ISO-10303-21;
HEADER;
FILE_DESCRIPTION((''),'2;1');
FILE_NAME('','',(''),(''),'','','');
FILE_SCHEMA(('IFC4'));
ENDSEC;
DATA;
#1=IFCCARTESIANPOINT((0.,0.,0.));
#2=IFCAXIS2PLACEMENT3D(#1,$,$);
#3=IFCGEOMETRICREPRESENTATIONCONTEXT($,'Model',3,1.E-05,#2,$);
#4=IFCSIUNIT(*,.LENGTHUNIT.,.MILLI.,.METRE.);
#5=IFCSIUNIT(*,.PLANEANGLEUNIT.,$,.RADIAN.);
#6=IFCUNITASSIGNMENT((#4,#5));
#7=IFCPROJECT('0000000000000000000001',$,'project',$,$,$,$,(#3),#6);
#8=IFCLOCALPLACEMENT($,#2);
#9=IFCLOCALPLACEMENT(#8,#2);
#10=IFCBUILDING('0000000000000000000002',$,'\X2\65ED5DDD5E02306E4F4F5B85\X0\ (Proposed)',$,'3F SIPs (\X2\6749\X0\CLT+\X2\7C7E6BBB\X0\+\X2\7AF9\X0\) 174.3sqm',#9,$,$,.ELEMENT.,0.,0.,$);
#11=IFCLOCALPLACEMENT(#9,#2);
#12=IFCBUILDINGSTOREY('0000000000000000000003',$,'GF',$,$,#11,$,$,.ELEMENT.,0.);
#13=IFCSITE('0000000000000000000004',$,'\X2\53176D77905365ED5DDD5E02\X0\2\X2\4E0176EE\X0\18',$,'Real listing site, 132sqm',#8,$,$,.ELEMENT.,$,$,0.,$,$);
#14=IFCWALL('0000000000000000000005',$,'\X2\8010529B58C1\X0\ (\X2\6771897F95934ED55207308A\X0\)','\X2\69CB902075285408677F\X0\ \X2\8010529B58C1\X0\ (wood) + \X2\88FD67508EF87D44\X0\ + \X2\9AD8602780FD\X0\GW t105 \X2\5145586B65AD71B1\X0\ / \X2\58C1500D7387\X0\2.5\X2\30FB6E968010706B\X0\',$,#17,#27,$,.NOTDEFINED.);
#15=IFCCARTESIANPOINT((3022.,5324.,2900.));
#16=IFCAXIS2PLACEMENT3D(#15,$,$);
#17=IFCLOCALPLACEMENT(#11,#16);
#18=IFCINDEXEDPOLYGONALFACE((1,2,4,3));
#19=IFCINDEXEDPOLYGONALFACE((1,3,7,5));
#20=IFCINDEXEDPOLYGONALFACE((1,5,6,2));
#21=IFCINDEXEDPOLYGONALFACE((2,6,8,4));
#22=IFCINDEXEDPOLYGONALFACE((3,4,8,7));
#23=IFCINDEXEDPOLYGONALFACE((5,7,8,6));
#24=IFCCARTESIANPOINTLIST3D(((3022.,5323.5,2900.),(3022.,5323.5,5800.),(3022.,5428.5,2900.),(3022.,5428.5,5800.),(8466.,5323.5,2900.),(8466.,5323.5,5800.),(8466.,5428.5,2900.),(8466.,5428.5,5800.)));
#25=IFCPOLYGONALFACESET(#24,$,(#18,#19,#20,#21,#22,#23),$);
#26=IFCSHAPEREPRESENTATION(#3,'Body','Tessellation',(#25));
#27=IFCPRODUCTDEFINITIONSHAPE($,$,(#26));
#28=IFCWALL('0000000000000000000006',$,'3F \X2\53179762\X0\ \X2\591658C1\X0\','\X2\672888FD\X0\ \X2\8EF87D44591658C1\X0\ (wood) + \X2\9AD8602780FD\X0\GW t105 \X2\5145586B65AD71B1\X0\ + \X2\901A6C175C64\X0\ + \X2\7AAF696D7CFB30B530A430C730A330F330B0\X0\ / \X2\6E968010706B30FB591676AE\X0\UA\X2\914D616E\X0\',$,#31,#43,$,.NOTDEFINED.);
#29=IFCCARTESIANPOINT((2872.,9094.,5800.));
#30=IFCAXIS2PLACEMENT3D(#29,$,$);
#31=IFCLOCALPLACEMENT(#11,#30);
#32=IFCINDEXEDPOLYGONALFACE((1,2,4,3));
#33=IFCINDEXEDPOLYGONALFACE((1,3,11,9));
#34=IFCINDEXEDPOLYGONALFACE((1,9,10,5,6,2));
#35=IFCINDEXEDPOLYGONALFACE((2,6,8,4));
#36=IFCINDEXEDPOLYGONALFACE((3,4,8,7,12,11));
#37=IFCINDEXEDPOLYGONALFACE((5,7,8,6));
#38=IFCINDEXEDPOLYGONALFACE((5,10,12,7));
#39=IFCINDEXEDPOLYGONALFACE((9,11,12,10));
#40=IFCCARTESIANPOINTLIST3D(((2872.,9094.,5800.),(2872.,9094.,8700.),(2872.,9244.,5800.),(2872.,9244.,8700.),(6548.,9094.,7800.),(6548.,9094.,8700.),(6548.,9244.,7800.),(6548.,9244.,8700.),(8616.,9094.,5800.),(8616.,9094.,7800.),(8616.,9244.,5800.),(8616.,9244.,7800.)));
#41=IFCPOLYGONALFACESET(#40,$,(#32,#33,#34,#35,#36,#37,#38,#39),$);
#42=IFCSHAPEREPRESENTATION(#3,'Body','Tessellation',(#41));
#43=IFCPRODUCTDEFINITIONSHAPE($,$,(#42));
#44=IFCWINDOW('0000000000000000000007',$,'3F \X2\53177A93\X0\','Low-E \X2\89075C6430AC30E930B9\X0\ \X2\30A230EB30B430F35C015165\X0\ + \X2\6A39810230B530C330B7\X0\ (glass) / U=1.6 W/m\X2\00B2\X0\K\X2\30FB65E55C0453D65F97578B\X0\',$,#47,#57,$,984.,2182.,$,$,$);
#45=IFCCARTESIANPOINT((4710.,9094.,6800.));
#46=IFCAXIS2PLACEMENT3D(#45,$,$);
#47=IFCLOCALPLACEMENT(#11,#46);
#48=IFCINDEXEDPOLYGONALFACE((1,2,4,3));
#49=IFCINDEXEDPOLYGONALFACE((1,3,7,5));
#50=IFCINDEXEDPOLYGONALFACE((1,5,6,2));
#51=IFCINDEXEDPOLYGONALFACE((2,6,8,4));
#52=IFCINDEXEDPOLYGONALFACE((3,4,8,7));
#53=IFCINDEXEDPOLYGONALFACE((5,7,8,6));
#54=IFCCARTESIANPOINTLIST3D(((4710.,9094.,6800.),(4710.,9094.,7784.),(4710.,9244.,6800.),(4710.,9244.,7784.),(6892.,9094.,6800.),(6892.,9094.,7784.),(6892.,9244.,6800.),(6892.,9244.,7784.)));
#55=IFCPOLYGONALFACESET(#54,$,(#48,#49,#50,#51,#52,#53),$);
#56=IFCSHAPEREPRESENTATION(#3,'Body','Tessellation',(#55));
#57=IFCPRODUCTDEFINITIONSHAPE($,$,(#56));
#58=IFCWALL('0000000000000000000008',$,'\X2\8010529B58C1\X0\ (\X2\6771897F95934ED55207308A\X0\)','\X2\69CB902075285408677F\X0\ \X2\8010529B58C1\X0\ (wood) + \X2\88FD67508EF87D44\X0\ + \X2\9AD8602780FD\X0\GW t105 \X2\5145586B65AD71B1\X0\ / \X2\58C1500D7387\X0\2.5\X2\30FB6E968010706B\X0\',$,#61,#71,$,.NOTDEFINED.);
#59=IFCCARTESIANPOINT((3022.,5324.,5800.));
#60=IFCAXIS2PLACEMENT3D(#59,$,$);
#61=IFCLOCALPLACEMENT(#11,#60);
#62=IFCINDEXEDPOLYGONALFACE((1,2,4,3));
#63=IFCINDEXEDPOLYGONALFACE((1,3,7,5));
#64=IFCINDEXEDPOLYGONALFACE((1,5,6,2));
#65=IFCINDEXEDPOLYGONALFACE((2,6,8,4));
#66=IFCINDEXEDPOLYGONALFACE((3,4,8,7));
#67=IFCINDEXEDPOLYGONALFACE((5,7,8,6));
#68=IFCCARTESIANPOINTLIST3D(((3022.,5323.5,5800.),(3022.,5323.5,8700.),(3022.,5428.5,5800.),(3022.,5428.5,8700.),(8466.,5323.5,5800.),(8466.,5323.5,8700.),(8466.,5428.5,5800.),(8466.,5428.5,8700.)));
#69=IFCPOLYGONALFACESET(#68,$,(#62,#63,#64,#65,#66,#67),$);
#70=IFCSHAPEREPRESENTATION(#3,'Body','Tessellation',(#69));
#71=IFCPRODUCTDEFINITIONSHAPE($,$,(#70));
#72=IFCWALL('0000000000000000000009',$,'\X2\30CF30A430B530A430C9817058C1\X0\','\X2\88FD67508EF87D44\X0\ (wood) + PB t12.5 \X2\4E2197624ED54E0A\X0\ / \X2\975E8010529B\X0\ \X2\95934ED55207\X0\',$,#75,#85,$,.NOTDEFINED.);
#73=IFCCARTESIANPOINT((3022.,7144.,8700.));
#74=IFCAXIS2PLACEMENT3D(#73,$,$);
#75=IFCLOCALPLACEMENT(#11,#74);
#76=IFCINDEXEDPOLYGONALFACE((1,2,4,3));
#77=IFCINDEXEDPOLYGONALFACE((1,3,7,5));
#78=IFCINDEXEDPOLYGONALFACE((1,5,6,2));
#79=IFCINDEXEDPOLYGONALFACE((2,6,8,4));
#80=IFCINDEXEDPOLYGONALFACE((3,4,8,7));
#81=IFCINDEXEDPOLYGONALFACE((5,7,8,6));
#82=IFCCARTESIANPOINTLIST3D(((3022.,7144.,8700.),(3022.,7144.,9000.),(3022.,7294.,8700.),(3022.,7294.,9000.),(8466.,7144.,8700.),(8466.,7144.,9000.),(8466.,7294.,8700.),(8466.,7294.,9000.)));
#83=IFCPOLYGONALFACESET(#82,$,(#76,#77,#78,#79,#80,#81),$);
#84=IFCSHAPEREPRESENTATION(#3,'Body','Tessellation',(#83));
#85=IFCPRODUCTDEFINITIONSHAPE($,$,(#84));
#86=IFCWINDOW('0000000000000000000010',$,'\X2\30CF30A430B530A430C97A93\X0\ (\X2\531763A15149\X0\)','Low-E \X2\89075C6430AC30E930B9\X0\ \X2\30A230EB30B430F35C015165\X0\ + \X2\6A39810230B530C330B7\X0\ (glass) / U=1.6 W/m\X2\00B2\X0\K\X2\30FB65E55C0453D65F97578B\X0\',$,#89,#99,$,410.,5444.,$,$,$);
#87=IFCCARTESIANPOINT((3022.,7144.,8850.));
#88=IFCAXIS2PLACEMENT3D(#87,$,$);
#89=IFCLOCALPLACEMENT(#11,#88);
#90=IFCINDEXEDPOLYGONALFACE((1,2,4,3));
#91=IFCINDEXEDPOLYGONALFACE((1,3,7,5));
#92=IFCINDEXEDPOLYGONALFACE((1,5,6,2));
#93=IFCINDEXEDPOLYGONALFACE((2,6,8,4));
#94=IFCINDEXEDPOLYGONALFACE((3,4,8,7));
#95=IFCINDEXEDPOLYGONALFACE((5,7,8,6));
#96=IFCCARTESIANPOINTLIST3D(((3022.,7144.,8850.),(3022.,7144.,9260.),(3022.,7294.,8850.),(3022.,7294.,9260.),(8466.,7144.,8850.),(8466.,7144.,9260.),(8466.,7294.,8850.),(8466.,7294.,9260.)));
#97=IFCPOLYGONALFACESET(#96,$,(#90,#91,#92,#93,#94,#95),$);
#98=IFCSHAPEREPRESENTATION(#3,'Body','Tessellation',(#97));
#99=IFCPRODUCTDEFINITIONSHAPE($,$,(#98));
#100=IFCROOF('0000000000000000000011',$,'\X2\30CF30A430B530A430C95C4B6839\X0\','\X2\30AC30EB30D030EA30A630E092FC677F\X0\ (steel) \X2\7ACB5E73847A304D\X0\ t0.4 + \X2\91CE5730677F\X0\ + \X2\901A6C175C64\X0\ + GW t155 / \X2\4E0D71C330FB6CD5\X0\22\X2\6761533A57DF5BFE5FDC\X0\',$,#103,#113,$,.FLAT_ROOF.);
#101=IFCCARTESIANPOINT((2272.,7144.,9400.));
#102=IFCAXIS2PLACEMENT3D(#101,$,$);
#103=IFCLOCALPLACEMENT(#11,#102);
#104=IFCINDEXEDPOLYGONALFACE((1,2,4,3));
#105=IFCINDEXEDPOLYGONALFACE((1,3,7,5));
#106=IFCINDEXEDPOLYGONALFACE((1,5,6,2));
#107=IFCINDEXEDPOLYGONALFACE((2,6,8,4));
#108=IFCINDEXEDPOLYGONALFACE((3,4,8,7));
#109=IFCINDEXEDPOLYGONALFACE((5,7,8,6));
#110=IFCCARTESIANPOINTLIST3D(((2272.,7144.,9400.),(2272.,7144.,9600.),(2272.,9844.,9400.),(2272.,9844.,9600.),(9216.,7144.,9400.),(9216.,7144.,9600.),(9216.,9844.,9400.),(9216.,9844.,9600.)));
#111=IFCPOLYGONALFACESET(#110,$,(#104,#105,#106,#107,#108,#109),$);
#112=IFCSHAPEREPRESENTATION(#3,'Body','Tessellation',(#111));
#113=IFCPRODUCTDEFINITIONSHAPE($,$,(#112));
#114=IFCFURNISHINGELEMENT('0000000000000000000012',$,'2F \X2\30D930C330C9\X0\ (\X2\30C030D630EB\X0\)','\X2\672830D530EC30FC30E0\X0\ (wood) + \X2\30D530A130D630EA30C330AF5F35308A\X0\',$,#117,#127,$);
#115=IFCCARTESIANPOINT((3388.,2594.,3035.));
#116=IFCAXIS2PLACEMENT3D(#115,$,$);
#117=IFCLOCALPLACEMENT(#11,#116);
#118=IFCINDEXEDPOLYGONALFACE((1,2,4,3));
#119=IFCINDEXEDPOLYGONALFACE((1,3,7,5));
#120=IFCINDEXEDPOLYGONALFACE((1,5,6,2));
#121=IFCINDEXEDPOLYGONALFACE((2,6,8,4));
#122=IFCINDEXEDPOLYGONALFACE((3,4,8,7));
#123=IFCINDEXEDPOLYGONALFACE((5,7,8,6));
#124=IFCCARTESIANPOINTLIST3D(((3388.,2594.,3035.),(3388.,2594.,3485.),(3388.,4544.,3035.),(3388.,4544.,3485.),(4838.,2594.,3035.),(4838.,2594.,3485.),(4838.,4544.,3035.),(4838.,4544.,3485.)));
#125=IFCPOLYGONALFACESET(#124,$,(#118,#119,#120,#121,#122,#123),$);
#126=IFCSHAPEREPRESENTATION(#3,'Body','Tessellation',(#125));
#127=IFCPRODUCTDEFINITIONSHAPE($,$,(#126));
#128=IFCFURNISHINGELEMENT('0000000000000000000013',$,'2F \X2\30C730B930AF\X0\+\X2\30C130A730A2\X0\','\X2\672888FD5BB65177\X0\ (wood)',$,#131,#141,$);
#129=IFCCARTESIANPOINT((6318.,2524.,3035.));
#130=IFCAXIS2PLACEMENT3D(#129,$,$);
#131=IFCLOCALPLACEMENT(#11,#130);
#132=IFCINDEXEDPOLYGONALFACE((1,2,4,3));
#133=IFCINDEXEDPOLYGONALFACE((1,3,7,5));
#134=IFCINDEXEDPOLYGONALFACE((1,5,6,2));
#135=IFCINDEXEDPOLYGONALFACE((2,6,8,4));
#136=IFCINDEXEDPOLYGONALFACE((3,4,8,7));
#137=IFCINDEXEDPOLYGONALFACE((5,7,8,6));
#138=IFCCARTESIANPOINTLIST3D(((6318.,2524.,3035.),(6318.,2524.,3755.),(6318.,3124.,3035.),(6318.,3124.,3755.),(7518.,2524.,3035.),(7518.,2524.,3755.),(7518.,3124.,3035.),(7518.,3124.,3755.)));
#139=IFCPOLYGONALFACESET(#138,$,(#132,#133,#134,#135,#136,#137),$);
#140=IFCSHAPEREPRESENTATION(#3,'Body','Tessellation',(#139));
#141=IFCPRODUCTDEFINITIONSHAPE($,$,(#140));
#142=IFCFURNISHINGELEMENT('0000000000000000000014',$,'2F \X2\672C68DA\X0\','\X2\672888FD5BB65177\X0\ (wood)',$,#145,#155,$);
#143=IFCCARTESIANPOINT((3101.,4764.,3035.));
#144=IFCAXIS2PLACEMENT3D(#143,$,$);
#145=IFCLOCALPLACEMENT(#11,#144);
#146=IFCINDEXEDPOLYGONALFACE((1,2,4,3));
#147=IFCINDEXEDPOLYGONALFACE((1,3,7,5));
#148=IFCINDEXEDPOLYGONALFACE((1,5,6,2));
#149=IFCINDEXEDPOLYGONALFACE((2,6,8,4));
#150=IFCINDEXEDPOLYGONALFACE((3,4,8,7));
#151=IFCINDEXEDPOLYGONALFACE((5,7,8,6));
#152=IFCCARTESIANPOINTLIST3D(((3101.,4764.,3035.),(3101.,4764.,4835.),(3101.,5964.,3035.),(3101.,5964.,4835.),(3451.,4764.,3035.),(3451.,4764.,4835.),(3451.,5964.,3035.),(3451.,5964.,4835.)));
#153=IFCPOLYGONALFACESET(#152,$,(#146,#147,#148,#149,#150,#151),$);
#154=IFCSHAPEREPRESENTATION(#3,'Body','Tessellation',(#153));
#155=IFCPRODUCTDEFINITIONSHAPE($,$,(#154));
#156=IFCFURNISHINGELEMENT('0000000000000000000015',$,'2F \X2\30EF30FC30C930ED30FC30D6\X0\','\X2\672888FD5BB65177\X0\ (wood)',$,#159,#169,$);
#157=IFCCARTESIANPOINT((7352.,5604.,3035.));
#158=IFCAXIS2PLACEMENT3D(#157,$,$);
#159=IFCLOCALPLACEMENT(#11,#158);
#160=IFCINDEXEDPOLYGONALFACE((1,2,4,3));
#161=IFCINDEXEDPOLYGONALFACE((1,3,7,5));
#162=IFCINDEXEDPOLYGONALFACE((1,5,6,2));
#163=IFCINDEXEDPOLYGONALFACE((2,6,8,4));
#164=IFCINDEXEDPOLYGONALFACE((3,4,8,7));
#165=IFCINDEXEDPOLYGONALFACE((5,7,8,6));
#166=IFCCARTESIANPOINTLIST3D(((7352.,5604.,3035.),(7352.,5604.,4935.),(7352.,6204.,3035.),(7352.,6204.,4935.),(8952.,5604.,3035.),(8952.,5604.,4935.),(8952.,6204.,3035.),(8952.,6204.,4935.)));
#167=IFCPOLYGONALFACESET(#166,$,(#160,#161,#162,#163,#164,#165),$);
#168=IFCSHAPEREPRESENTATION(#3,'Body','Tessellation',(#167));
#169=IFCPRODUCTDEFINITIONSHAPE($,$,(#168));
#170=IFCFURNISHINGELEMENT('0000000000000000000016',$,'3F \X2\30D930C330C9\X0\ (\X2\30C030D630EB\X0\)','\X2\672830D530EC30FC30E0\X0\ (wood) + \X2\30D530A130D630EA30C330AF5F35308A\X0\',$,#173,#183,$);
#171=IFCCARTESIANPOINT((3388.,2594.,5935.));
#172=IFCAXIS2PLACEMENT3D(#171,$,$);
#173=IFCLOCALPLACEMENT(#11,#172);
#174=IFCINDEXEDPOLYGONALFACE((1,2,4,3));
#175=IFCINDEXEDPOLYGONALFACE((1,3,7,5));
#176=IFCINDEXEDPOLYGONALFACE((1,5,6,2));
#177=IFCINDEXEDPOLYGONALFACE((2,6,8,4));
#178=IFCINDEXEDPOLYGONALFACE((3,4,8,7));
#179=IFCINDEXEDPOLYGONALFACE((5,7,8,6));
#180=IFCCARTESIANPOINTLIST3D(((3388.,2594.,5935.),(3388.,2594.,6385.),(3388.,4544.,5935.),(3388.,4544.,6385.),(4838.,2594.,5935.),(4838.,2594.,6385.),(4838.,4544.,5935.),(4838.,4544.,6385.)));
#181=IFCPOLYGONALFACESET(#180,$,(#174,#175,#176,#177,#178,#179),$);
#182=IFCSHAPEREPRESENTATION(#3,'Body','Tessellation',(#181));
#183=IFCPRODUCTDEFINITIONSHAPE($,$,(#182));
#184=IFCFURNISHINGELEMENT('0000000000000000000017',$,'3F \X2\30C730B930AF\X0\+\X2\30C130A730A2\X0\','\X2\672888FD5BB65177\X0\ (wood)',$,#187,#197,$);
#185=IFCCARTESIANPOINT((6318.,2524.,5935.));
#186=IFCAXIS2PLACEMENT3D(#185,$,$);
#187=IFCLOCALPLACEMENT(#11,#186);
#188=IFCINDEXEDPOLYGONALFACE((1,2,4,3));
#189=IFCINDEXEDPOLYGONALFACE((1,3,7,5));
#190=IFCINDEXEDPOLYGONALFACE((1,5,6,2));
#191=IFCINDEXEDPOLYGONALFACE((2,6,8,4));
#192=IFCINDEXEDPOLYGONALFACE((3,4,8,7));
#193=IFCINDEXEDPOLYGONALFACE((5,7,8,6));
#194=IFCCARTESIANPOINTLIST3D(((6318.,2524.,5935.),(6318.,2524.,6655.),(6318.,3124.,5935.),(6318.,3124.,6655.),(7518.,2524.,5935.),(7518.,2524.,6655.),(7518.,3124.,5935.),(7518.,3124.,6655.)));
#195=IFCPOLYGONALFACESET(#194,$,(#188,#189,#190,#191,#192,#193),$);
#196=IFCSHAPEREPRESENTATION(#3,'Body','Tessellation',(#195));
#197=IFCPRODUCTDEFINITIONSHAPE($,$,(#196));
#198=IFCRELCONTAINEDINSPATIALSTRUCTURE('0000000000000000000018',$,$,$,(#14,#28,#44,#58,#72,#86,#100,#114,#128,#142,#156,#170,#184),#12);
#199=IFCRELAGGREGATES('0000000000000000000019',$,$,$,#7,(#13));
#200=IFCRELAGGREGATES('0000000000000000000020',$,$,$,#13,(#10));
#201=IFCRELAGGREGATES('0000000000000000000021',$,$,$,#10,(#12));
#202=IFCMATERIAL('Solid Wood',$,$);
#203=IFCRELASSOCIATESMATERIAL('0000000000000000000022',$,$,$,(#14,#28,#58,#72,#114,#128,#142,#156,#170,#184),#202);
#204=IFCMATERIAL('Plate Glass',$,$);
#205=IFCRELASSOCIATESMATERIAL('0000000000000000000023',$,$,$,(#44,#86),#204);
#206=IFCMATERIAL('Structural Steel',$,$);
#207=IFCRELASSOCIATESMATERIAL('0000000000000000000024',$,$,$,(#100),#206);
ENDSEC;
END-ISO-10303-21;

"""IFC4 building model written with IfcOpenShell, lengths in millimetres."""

from ifc_helpers import new_model, si_unit, frame, frame_2d, origin, place, context, project, spatial, rectangle, extrude, material, element, fill, save


model = new_model("IFC4")

# Units and contexts
model_context = context("Model", 3, precision=1e-05, world=origin())
ifc_project = project(units=[si_unit("LENGTHUNIT", "METRE", prefix="MILLI"), si_unit("PLANEANGLEUNIT", "RADIAN")], contexts=[model_context])

# Site, building, storey
site_placement = place(None, origin())
site = spatial("IfcSite", under=ifc_project, at=site_placement, Name="北海道旭川市2丁目18", ObjectType="Real listing site, 132sqm", CompositionType="ELEMENT", RefElevation=0.0)
building_placement = place(site_placement, origin())
building = spatial("IfcBuilding", under=site, at=building_placement, Name="旭川市の住宅 (Proposed)", ObjectType="3F SIPs (杉CLT+籾殻+竹) 174.3sqm", CompositionType="ELEMENT", ElevationOfRefHeight=0.0, ElevationOfTerrain=0.0)
storey_placement = place(building_placement, origin())
storey = spatial("IfcBuildingStorey", under=building, at=storey_placement, Name="GF", CompositionType="ELEMENT", Elevation=0.0)

# Wall
ifc_material_1 = material(Name="Solid Wood")
wall_1_placement = place(storey_placement, frame((3022.0, 5324.0, 2900.0)))
element("IfcWall", 1, at=wall_1_placement, inside=storey, material=ifc_material_1, Name="耐力壁 (東西間仕切り)", Description="構造用合板 耐力壁 (wood) + 製材軸組 + 高性能GW t105 充填断熱 / 壁倍率2.5・準耐火", PredefinedType="NOTDEFINED", context=model_context, shape_type="SweptSolid", body=[
    extrude(rectangle(XDim=5444.0, YDim=105.0, at=frame_2d((2722.0, 52.0))), frame((3022.0, 5324.0, 2900.0)), (0.0, 0.0, 1.0), 2900.0),
])

# Wall, opening, window
wall_2_placement = place(storey_placement, frame((2872.0, 9094.0, 5800.0)))
wall_2 = element("IfcWall", 2, at=wall_2_placement, inside=storey, material=ifc_material_1, Name="3F 北面 外壁", Description="木製 軸組外壁 (wood) + 高性能GW t105 充填断熱 + 通気層 + 窯業系サイディング / 準耐火・外皮UA配慮", PredefinedType="NOTDEFINED", context=model_context, shape_type="SweptSolid", body=[
    extrude(rectangle(XDim=5744.0, YDim=150.0, at=frame_2d((2872.0, 75.0))), frame((2872.0, 9094.0, 5800.0)), (0.0, 0.0, 1.0), 2900.0),
])
opening_1_placement = place(storey_placement, frame((4710.0, 9094.0, 6800.0)))
opening_1 = element("IfcOpeningElement", 3, at=opening_1_placement, cuts=wall_2, PredefinedType="NOTDEFINED", context=model_context, shape_type="SweptSolid", body=[
    extrude(rectangle(XDim=2182.0, YDim=150.0, at=frame_2d((1091.0, 75.0))), frame((4710.0, 9094.0, 6800.0)), (0.0, 0.0, 1.0), 984.0),
])
ifc_material_2 = material(Name="Plate Glass")
window_1_placement = place(storey_placement, frame((4710.0, 9094.0, 6800.0)))
window_1 = element("IfcWindow", 4, at=window_1_placement, inside=storey, material=ifc_material_2, Name="3F 北窓", Description="Low-E 複層ガラス アルゴン封入 + 樹脂サッシ (glass) / U=1.6 W/m²K・日射取得型", OverallHeight=984.0, OverallWidth=2182.0, context=model_context, shape_type="SweptSolid", body=[
    extrude(rectangle(XDim=2182.0, YDim=150.0, at=frame_2d((1091.0, 75.0))), frame((4710.0, 9094.0, 6800.0)), (0.0, 0.0, 1.0), 984.0),
])
fill(opening_1, window_1)

# Wall
wall_3_placement = place(storey_placement, frame((3022.0, 5324.0, 5800.0)))
element("IfcWall", 5, at=wall_3_placement, inside=storey, material=ifc_material_1, Name="耐力壁 (東西間仕切り)", Description="構造用合板 耐力壁 (wood) + 製材軸組 + 高性能GW t105 充填断熱 / 壁倍率2.5・準耐火", PredefinedType="NOTDEFINED", context=model_context, shape_type="SweptSolid", body=[
    extrude(rectangle(XDim=5444.0, YDim=105.0, at=frame_2d((2722.0, 52.0))), frame((3022.0, 5324.0, 5800.0)), (0.0, 0.0, 1.0), 2900.0),
])

# Wall, opening, window
wall_4_placement = place(storey_placement, frame((3022.0, 7144.0, 8700.0)))
wall_4 = element("IfcWall", 6, at=wall_4_placement, inside=storey, material=ifc_material_1, Name="ハイサイド腰壁", Description="製材軸組 (wood) + PB t12.5 両面仕上 / 非耐力 間仕切", PredefinedType="NOTDEFINED", context=model_context, shape_type="SweptSolid", body=[
    extrude(rectangle(XDim=5444.0, YDim=150.0, at=frame_2d((2722.0, 75.0))), frame((3022.0, 7144.0, 8700.0)), (0.0, 0.0, 1.0), 700.0),
])
opening_2_placement = place(storey_placement, frame((3022.0, 7144.0, 8850.0)))
opening_2 = element("IfcOpeningElement", 7, at=opening_2_placement, cuts=wall_4, PredefinedType="NOTDEFINED", context=model_context, shape_type="SweptSolid", body=[
    extrude(rectangle(XDim=5444.0, YDim=150.0, at=frame_2d((2722.0, 75.0))), frame((3022.0, 7144.0, 8850.0)), (0.0, 0.0, 1.0), 410.0),
])
window_2_placement = place(storey_placement, frame((3022.0, 7144.0, 8850.0)))
window_2 = element("IfcWindow", 8, at=window_2_placement, inside=storey, material=ifc_material_2, Name="ハイサイド窓 (北採光)", Description="Low-E 複層ガラス アルゴン封入 + 樹脂サッシ (glass) / U=1.6 W/m²K・日射取得型", OverallHeight=410.0, OverallWidth=5444.0, context=model_context, shape_type="SweptSolid", body=[
    extrude(rectangle(XDim=5444.0, YDim=150.0, at=frame_2d((2722.0, 75.0))), frame((3022.0, 7144.0, 8850.0)), (0.0, 0.0, 1.0), 410.0),
])
fill(opening_2, window_2)

# Roof
ifc_material_3 = material(Name="Structural Steel")
roof_placement = place(storey_placement, frame((2272.0, 7144.0, 9400.0)))
element("IfcRoof", 9, at=roof_placement, inside=storey, material=ifc_material_3, Name="ハイサイド屋根", Description="ガルバリウム鋼板 (steel) 立平葺き t0.4 + 野地板 + 通気層 + GW t155 / 不燃・法22条区域対応", PredefinedType="FLAT_ROOF", context=model_context, shape_type="SweptSolid", body=[
    extrude(rectangle(XDim=6944.0, YDim=2700.0, at=frame_2d((3472.0, 1350.0))), frame((2272.0, 7144.0, 9400.0)), (0.0, 0.0, 1.0), 200.0),
])

# Furnishing elements
furnishing_1_placement = place(storey_placement, frame((3388.0, 2594.0, 3035.0)))
element("IfcFurnishingElement", 10, at=furnishing_1_placement, inside=storey, material=ifc_material_1, Name="2F ベッド (ダブル)", Description="木フレーム (wood) + ファブリック張り", context=model_context, shape_type="SweptSolid", body=[
    extrude(rectangle(XDim=1450.0, YDim=1950.0, at=frame_2d((725.0, 975.0))), frame((3388.0, 2594.0, 3035.0)), (0.0, 0.0, 1.0), 450.0),
])
furnishing_2_placement = place(storey_placement, frame((6318.0, 2524.0, 3035.0)))
element("IfcFurnishingElement", 11, at=furnishing_2_placement, inside=storey, material=ifc_material_1, Name="2F デスク+チェア", Description="木製家具 (wood)", context=model_context, shape_type="SweptSolid", body=[
    extrude(rectangle(XDim=1200.0, YDim=600.0, at=frame_2d((600.0, 300.0))), frame((6318.0, 2524.0, 3035.0)), (0.0, 0.0, 1.0), 720.0),
])
furnishing_3_placement = place(storey_placement, frame((3101.0, 4764.0, 3035.0)))
element("IfcFurnishingElement", 12, at=furnishing_3_placement, inside=storey, material=ifc_material_1, Name="2F 本棚", Description="木製家具 (wood)", context=model_context, shape_type="SweptSolid", body=[
    extrude(rectangle(XDim=350.0, YDim=1200.0, at=frame_2d((175.0, 600.0))), frame((3101.0, 4764.0, 3035.0)), (0.0, 0.0, 1.0), 1800.0),
])
furnishing_4_placement = place(storey_placement, frame((7352.0, 5604.0, 3035.0)))
element("IfcFurnishingElement", 13, at=furnishing_4_placement, inside=storey, material=ifc_material_1, Name="2F ワードローブ", Description="木製家具 (wood)", context=model_context, shape_type="SweptSolid", body=[
    extrude(rectangle(XDim=1600.0, YDim=600.0, at=frame_2d((800.0, 300.0))), frame((7352.0, 5604.0, 3035.0)), (0.0, 0.0, 1.0), 1900.0),
])
furnishing_5_placement = place(storey_placement, frame((3388.0, 2594.0, 5935.0)))
element("IfcFurnishingElement", 14, at=furnishing_5_placement, inside=storey, material=ifc_material_1, Name="3F ベッド (ダブル)", Description="木フレーム (wood) + ファブリック張り", context=model_context, shape_type="SweptSolid", body=[
    extrude(rectangle(XDim=1450.0, YDim=1950.0, at=frame_2d((725.0, 975.0))), frame((3388.0, 2594.0, 5935.0)), (0.0, 0.0, 1.0), 450.0),
])
furnishing_6_placement = place(storey_placement, frame((6318.0, 2524.0, 5935.0)))
element("IfcFurnishingElement", 15, at=furnishing_6_placement, inside=storey, material=ifc_material_1, Name="3F デスク+チェア", Description="木製家具 (wood)", context=model_context, shape_type="SweptSolid", body=[
    extrude(rectangle(XDim=1200.0, YDim=600.0, at=frame_2d((600.0, 300.0))), frame((6318.0, 2524.0, 5935.0)), (0.0, 0.0, 1.0), 720.0),
])

save(model, "model.ifc")
